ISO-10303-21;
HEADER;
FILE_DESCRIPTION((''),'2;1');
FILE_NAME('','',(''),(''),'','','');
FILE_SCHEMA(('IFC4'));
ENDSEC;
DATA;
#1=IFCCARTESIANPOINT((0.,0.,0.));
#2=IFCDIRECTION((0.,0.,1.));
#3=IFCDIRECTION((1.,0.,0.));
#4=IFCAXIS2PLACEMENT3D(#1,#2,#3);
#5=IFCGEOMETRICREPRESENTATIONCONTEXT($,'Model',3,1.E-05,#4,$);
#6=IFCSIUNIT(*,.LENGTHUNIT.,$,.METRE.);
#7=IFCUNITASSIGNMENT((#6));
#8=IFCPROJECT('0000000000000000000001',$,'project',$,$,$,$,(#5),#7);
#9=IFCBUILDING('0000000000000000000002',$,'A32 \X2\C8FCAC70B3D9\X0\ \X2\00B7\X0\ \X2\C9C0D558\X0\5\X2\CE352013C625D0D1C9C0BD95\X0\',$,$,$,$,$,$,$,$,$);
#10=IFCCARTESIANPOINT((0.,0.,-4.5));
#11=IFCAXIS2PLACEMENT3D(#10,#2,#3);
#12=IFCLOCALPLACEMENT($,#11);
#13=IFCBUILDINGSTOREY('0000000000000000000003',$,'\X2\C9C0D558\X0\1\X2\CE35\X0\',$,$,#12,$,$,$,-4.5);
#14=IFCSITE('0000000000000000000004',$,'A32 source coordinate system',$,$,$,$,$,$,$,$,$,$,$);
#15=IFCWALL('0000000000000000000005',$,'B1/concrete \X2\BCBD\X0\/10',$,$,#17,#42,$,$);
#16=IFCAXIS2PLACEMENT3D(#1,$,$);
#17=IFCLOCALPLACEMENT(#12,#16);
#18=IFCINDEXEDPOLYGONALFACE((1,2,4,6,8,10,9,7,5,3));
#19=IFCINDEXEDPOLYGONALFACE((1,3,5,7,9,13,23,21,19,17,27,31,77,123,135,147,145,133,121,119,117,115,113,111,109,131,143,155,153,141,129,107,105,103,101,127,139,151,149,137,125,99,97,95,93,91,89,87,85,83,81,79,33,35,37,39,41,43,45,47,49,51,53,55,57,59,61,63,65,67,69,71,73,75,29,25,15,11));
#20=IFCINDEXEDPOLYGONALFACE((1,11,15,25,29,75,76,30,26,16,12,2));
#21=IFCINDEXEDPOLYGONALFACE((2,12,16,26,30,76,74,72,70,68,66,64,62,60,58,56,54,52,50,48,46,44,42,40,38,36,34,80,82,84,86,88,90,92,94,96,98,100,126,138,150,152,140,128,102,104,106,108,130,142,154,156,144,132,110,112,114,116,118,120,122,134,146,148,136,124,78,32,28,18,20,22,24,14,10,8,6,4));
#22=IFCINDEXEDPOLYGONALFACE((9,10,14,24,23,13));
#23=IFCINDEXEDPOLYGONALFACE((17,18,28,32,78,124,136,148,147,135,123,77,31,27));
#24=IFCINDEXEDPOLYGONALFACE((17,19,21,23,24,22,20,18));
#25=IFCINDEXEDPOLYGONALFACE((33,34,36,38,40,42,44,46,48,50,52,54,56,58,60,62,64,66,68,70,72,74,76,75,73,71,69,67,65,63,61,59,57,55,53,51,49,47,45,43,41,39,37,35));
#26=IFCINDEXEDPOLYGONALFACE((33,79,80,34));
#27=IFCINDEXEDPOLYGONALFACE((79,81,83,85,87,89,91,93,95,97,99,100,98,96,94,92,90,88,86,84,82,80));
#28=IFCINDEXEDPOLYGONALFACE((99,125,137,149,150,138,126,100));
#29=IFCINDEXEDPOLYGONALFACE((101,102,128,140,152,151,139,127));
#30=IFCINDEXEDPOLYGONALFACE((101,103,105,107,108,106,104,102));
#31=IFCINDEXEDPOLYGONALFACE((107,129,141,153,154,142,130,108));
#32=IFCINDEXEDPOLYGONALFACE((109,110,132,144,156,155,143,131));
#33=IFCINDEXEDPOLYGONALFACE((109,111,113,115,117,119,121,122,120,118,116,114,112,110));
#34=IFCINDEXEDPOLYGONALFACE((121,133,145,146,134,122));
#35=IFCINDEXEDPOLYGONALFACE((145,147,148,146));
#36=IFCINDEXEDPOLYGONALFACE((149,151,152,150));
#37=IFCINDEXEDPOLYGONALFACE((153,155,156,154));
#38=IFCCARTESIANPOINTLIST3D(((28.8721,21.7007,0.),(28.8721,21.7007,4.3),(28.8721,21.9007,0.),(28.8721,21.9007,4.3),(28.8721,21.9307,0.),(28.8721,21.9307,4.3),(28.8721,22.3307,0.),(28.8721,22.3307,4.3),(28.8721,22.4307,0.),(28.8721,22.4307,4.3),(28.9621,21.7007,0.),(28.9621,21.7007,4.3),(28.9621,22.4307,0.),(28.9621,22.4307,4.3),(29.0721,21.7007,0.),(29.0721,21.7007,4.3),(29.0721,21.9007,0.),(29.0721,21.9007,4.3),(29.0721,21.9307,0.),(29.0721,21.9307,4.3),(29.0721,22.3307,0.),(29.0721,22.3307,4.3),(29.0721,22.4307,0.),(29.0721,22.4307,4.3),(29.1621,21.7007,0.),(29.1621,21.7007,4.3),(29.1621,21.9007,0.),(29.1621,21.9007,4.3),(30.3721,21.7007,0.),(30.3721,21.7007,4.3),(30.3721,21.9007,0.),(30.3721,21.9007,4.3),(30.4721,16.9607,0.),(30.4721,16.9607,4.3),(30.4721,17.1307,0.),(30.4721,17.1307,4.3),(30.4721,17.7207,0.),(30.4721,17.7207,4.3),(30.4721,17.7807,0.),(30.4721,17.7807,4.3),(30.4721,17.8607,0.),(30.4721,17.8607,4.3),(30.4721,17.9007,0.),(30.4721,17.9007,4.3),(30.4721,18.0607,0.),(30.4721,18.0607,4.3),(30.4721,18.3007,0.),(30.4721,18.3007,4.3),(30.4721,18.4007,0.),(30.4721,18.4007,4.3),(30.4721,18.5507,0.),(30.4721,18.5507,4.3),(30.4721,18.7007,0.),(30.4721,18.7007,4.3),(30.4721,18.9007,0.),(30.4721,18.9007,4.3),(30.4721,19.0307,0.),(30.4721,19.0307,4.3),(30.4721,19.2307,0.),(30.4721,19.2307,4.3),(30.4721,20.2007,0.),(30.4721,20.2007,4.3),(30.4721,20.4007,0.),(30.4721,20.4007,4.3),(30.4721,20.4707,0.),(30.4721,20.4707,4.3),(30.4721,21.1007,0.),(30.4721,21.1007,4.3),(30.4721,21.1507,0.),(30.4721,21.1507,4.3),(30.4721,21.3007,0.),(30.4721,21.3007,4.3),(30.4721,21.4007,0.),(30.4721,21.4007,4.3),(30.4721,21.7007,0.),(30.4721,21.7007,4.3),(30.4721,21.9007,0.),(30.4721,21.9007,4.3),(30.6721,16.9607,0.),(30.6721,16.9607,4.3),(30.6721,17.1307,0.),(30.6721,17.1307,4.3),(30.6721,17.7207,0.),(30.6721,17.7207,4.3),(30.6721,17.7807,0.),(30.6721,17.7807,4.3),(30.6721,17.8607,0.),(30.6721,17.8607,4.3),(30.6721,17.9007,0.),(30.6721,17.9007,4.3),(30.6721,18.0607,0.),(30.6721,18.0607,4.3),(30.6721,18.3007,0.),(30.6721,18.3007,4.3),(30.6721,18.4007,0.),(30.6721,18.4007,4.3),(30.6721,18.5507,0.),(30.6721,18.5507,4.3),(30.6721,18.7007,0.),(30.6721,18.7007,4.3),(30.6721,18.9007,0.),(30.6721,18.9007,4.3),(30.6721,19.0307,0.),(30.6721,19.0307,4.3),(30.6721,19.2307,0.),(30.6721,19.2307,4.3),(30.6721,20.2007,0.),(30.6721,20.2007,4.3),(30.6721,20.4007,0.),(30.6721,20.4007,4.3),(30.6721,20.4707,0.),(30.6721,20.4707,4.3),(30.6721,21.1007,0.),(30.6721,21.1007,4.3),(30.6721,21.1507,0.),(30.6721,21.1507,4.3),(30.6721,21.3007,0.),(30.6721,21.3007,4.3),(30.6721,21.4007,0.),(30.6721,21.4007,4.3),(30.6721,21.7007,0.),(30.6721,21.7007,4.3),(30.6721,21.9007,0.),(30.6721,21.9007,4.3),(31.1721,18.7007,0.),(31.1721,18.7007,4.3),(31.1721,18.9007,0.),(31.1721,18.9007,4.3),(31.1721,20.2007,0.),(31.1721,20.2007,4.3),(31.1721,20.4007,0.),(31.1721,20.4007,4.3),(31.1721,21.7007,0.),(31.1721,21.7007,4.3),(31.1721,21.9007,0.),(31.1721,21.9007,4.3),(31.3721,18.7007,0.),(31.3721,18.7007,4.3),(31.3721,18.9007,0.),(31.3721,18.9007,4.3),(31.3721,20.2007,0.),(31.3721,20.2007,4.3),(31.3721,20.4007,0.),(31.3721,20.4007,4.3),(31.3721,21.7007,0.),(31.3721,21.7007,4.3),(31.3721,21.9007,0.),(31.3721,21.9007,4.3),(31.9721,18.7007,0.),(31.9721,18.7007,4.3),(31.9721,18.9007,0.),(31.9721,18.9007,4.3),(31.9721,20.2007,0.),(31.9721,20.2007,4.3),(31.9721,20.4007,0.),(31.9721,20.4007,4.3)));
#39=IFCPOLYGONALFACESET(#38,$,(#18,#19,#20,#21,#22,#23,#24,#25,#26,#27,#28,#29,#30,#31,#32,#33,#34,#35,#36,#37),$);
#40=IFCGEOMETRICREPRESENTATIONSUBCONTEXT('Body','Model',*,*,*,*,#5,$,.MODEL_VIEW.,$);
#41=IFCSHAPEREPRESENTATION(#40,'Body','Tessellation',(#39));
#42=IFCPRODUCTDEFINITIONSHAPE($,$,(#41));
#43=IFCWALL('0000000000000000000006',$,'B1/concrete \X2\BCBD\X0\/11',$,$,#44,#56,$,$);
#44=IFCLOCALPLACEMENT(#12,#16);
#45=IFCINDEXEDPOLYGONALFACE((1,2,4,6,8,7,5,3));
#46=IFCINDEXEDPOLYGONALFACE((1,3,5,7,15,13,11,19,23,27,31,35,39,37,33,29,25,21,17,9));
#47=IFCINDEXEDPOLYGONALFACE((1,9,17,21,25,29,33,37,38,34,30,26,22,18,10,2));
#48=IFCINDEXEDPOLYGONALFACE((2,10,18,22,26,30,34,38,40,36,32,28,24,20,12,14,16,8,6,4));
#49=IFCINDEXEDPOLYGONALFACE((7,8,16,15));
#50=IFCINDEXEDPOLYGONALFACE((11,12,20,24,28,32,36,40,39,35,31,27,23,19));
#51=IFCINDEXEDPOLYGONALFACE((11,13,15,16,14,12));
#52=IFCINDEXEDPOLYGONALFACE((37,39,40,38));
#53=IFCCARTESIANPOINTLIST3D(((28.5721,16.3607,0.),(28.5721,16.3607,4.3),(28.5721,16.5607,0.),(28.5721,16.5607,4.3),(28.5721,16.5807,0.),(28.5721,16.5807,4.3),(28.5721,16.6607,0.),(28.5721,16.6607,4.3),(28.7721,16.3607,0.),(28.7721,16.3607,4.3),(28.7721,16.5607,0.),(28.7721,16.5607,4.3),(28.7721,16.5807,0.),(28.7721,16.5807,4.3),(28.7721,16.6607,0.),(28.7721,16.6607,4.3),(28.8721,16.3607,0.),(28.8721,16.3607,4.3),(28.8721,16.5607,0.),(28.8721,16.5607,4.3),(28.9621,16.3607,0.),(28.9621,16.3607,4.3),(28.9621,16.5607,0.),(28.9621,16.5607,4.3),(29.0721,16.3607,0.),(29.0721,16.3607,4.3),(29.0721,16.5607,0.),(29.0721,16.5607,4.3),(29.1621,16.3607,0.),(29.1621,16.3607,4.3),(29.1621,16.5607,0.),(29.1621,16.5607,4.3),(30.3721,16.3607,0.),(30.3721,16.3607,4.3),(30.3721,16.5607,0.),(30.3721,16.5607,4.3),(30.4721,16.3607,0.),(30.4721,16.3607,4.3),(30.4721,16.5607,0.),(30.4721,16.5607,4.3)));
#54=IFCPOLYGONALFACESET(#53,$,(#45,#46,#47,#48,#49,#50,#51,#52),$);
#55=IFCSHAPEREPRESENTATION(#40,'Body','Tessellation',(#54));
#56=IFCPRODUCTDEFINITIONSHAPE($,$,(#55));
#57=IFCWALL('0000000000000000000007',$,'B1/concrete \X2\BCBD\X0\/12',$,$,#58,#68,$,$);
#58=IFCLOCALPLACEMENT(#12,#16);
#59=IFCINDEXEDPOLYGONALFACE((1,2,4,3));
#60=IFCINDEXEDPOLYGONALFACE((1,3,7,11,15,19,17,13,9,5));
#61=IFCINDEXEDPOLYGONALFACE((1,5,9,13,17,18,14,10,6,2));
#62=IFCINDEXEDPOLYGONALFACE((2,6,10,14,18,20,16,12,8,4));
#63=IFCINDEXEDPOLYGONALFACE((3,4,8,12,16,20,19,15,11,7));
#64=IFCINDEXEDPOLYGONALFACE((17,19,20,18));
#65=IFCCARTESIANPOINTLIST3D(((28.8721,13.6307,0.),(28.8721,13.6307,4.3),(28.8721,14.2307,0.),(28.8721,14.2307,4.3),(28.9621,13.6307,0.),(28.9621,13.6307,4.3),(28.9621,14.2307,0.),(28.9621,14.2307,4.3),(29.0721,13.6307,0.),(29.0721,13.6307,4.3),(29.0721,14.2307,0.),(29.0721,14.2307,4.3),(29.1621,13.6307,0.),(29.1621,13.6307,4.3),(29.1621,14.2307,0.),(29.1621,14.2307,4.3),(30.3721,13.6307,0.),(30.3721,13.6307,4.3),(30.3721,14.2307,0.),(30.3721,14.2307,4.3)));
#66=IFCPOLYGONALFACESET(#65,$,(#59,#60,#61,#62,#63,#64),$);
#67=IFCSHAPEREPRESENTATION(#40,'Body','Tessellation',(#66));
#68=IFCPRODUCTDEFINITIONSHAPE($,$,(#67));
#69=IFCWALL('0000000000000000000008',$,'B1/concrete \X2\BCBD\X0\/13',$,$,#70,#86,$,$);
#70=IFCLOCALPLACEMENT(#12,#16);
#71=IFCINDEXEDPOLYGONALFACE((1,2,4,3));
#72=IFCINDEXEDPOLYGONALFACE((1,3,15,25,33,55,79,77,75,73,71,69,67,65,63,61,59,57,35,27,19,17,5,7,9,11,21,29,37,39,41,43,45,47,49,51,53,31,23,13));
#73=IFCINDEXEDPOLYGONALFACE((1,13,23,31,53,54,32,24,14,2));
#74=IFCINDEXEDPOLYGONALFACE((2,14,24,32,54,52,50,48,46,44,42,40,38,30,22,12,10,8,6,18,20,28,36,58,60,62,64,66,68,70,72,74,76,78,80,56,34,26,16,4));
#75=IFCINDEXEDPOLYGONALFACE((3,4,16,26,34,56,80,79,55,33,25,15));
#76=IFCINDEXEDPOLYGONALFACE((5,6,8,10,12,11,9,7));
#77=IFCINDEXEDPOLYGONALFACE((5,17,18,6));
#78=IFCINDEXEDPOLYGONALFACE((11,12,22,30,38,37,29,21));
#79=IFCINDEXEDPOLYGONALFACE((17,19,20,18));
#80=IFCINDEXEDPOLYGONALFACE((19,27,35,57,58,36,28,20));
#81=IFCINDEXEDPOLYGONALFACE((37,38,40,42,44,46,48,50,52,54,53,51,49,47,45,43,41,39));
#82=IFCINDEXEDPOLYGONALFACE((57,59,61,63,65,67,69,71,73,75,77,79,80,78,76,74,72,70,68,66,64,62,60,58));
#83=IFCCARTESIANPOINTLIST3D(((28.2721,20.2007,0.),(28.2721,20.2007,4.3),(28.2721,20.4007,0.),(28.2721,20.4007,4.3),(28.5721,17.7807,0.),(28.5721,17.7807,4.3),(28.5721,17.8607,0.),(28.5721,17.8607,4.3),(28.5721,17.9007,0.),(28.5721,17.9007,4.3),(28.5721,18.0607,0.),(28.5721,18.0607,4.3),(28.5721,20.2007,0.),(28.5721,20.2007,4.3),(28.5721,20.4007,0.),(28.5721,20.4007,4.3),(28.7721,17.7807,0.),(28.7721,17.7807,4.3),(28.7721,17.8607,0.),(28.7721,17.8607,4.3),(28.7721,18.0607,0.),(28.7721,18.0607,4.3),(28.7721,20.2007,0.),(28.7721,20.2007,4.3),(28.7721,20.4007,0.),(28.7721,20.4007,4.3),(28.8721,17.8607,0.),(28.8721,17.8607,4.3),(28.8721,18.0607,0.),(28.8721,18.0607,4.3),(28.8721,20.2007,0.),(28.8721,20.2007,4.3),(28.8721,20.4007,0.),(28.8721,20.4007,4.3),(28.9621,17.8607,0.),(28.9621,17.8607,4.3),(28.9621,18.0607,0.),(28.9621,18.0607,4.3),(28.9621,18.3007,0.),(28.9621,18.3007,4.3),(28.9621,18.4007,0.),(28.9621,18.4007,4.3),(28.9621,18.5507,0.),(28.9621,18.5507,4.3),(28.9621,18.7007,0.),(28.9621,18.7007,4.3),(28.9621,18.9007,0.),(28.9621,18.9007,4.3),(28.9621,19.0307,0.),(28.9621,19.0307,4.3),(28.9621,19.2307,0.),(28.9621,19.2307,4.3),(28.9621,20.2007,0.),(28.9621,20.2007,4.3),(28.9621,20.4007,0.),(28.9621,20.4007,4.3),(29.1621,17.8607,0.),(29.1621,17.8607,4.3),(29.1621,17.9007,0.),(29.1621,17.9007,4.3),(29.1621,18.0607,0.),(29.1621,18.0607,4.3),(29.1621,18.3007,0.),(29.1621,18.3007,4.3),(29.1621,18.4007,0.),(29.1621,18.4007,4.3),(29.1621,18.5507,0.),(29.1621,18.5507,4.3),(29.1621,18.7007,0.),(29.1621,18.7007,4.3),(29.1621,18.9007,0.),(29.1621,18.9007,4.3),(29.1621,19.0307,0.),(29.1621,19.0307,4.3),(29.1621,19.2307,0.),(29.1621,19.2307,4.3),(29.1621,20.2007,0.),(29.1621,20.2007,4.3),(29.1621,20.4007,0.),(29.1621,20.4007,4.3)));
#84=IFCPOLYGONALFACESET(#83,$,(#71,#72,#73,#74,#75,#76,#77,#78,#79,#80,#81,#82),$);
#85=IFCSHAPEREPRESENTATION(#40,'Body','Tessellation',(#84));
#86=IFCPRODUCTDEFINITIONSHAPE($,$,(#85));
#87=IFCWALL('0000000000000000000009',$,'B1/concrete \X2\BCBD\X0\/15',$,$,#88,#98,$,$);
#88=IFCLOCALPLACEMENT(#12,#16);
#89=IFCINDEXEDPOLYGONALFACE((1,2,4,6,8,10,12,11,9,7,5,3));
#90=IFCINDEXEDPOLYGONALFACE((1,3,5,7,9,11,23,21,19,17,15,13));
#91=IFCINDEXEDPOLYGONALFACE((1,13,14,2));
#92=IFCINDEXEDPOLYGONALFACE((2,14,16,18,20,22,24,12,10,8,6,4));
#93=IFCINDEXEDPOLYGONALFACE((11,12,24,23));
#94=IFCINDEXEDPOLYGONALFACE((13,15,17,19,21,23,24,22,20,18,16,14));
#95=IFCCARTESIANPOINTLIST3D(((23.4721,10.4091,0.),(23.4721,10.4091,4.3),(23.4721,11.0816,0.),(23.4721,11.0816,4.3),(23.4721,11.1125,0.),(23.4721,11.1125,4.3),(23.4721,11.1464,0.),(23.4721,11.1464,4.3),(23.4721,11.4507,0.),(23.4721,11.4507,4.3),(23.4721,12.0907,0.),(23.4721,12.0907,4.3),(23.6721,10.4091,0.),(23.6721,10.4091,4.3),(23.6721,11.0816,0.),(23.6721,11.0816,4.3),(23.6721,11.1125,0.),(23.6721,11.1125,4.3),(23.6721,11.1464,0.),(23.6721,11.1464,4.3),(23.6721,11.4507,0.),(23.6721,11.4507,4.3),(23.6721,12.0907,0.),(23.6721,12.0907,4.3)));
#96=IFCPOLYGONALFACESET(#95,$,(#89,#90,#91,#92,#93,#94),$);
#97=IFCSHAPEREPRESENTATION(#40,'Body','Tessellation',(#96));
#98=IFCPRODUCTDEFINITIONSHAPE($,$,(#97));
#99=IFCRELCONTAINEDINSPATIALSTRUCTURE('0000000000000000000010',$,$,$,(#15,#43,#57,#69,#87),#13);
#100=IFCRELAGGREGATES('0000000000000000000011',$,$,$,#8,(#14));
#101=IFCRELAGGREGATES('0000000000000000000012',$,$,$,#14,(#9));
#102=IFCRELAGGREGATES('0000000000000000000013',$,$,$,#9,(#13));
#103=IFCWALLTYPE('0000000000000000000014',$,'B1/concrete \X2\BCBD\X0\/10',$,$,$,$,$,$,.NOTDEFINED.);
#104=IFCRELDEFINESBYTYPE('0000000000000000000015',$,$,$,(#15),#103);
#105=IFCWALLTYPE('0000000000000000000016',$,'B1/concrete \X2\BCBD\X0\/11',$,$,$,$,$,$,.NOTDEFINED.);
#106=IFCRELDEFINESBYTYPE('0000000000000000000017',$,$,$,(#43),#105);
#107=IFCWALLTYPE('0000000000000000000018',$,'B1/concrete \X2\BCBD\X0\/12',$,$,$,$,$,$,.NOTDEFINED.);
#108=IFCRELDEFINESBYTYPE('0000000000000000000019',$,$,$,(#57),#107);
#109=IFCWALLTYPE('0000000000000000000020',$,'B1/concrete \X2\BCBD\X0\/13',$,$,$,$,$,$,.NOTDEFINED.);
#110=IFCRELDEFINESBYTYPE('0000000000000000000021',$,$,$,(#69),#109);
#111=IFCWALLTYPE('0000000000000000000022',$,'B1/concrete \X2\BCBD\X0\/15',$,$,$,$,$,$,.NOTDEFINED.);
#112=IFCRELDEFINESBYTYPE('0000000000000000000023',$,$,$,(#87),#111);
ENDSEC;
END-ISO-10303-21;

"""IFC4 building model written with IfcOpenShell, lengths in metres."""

from ifc_helpers import new_model, si_unit, frame, origin, origin_with_axes, place, context, subcontext, project, spatial, polyline, outline, extrude, source, transform, mapped, type_object, type_shapes, element, save


model = new_model("IFC4")

# Units and contexts
model_context = context("Model", 3, precision=1e-05, world=origin_with_axes())
body_context = subcontext(model_context, "Body", "Model", "MODEL_VIEW")
ifc_project = project(units=[si_unit("LENGTHUNIT", "METRE")], contexts=[model_context])

# Site, building, storey
site = spatial("IfcSite", under=ifc_project, Name="A32 source coordinate system")
building = spatial("IfcBuilding", under=site, Name="A32 주거동 · 지하5층–옥탑지붕")
storey_placement = place(None, frame((0.0, 0.0, -4.5), z_axis=(0.0, 0.0, 1.0), x_axis=(1.0, 0.0, 0.0)))
storey = spatial("IfcBuildingStorey", under=building, at=storey_placement, Name="지하1층", Elevation=-4.5)

# Walls
wall_type_1 = type_object("IfcWallType", Name="B1/concrete 벽/10", PredefinedType="NOTDEFINED")
shared_shape_1 = source(origin(), body_context, "Body", "SweptSolid", [
    extrude(outline(polyline([(30.6721, 21.4007), (30.6721, 21.3007), (30.6721, 21.1507), (30.6721, 21.1007), (30.6721, 20.4707), (30.6721, 20.4007), (31.1721, 20.4007), (31.3721, 20.4007), (31.9721, 20.4007), (31.9721, 20.2007), (31.3721, 20.2007), (31.1721, 20.2007), (30.6721, 20.2007), (30.6721, 19.2307), (30.6721, 19.0307), (30.6721, 18.9007), (31.1721, 18.9007), (31.3721, 18.9007), (31.9721, 18.9007), (31.9721, 18.7007), (31.3721, 18.7007), (31.1721, 18.7007), (30.6721, 18.7007), (30.6721, 18.5507), (30.6721, 18.4007), (30.6721, 18.3007), (30.6721, 18.0607), (30.6721, 17.9007), (30.6721, 17.8607), (30.6721, 17.7807), (30.6721, 17.7207), (30.6721, 17.1307), (30.6721, 16.9607), (30.4721, 16.9607), (30.4721, 17.1307), (30.4721, 17.7207), (30.4721, 17.7807), (30.4721, 17.8607), (30.4721, 17.9007), (30.4721, 18.0607), (30.4721, 18.3007), (30.4721, 18.4007), (30.4721, 18.5507), (30.4721, 18.7007), (30.4721, 18.9007), (30.4721, 19.0307), (30.4721, 19.2307), (30.4721, 20.2007), (30.4721, 20.4007), (30.4721, 20.4707), (30.4721, 21.1007), (30.4721, 21.1507), (30.4721, 21.3007), (30.4721, 21.4007), (30.4721, 21.7007), (30.3721, 21.7007), (29.1621, 21.7007), (29.0721, 21.7007), (28.9621, 21.7007), (28.8721, 21.7007), (28.8721, 21.9007), (28.8721, 21.9307), (28.8721, 22.3307), (28.8721, 22.4307), (28.9621, 22.4307), (29.0721, 22.4307), (29.0721, 22.3307), (29.0721, 21.9307), (29.0721, 21.9007), (29.1621, 21.9007), (30.3721, 21.9007), (30.4721, 21.9007), (30.6721, 21.9007), (31.1721, 21.9007), (31.3721, 21.9007), (31.3721, 21.7007), (31.1721, 21.7007), (30.6721, 21.7007), (30.6721, 21.4007)])), origin(), (0.0, 0.0, 1.0), 4.3),
])
type_shapes(wall_type_1, [shared_shape_1])
wall_1_placement = place(storey_placement, origin_with_axes())
element("IfcWall", 1, at=wall_1_placement, inside=storey, type_object=wall_type_1, Name="B1/concrete 벽/10", context=body_context, shape_type="MappedRepresentation", body=[
    mapped(shared_shape_1, transform((0.0, 0.0, 0.0), scale=1.0)),
])
wall_type_2 = type_object("IfcWallType", Name="B1/concrete 벽/11", PredefinedType="NOTDEFINED")
shared_shape_2 = source(origin(), body_context, "Body", "SweptSolid", [
    extrude(outline(polyline([(29.0721, 16.3607), (28.9621, 16.3607), (28.8721, 16.3607), (28.7721, 16.3607), (28.5721, 16.3607), (28.5721, 16.5607), (28.5721, 16.5807), (28.5721, 16.6607), (28.7721, 16.6607), (28.7721, 16.5807), (28.7721, 16.5607), (28.8721, 16.5607), (28.9621, 16.5607), (29.0721, 16.5607), (29.1621, 16.5607), (30.3721, 16.5607), (30.4721, 16.5607), (30.4721, 16.3607), (30.3721, 16.3607), (29.1621, 16.3607), (29.0721, 16.3607)])), origin(), (0.0, 0.0, 1.0), 4.3),
])
type_shapes(wall_type_2, [shared_shape_2])
wall_2_placement = place(storey_placement, origin_with_axes())
element("IfcWall", 2, at=wall_2_placement, inside=storey, type_object=wall_type_2, Name="B1/concrete 벽/11", context=body_context, shape_type="MappedRepresentation", body=[
    mapped(shared_shape_2, transform((0.0, 0.0, 0.0), scale=1.0)),
])
wall_type_3 = type_object("IfcWallType", Name="B1/concrete 벽/12", PredefinedType="NOTDEFINED")
shared_shape_3 = source(origin(), body_context, "Body", "SweptSolid", [
    extrude(outline(polyline([(29.1621, 14.2307), (30.3721, 14.2307), (30.3721, 13.6307), (29.1621, 13.6307), (29.0721, 13.6307), (28.9621, 13.6307), (28.8721, 13.6307), (28.8721, 14.2307), (28.9621, 14.2307), (29.0721, 14.2307), (29.1621, 14.2307)])), origin(), (0.0, 0.0, 1.0), 4.3),
])
type_shapes(wall_type_3, [shared_shape_3])
wall_3_placement = place(storey_placement, origin_with_axes())
element("IfcWall", 3, at=wall_3_placement, inside=storey, type_object=wall_type_3, Name="B1/concrete 벽/12", context=body_context, shape_type="MappedRepresentation", body=[
    mapped(shared_shape_3, transform((0.0, 0.0, 0.0), scale=1.0)),
])
wall_type_4 = type_object("IfcWallType", Name="B1/concrete 벽/13", PredefinedType="NOTDEFINED")
shared_shape_4 = source(origin(), body_context, "Body", "SweptSolid", [
    extrude(outline(polyline([(28.5721, 18.0607), (28.7721, 18.0607), (28.8721, 18.0607), (28.9621, 18.0607), (28.9621, 18.3007), (28.9621, 18.4007), (28.9621, 18.5507), (28.9621, 18.7007), (28.9621, 18.9007), (28.9621, 19.0307), (28.9621, 19.2307), (28.9621, 20.2007), (28.8721, 20.2007), (28.7721, 20.2007), (28.5721, 20.2007), (28.2721, 20.2007), (28.2721, 20.4007), (28.5721, 20.4007), (28.7721, 20.4007), (28.8721, 20.4007), (28.9621, 20.4007), (29.1621, 20.4007), (29.1621, 20.2007), (29.1621, 19.2307), (29.1621, 19.0307), (29.1621, 18.9007), (29.1621, 18.7007), (29.1621, 18.5507), (29.1621, 18.4007), (29.1621, 18.3007), (29.1621, 18.0607), (29.1621, 17.9007), (29.1621, 17.8607), (28.9621, 17.8607), (28.8721, 17.8607), (28.7721, 17.8607), (28.7721, 17.7807), (28.5721, 17.7807), (28.5721, 17.8607), (28.5721, 17.9007), (28.5721, 18.0607)])), origin(), (0.0, 0.0, 1.0), 4.3),
])
type_shapes(wall_type_4, [shared_shape_4])
wall_4_placement = place(storey_placement, origin_with_axes())
element("IfcWall", 4, at=wall_4_placement, inside=storey, type_object=wall_type_4, Name="B1/concrete 벽/13", context=body_context, shape_type="MappedRepresentation", body=[
    mapped(shared_shape_4, transform((0.0, 0.0, 0.0), scale=1.0)),
])
wall_type_5 = type_object("IfcWallType", Name="B1/concrete 벽/15", PredefinedType="NOTDEFINED")
shared_shape_5 = source(origin(), body_context, "Body", "SweptSolid", [
    extrude(outline(polyline([(23.6721, 11.1125), (23.6721, 11.0816), (23.6721, 10.4091), (23.4721, 10.4091), (23.4721, 11.0816), (23.4721, 11.1125), (23.4721, 11.1464), (23.4721, 11.4507), (23.4721, 12.0907), (23.6721, 12.0907), (23.6721, 11.4507), (23.6721, 11.1464), (23.6721, 11.1125)])), origin(), (0.0, 0.0, 1.0), 4.3),
])
type_shapes(wall_type_5, [shared_shape_5])
wall_5_placement = place(storey_placement, origin_with_axes())
element("IfcWall", 5, at=wall_5_placement, inside=storey, type_object=wall_type_5, Name="B1/concrete 벽/15", context=body_context, shape_type="MappedRepresentation", body=[
    mapped(shared_shape_5, transform((0.0, 0.0, 0.0), scale=1.0)),
])

save(model, "model.ifc")
